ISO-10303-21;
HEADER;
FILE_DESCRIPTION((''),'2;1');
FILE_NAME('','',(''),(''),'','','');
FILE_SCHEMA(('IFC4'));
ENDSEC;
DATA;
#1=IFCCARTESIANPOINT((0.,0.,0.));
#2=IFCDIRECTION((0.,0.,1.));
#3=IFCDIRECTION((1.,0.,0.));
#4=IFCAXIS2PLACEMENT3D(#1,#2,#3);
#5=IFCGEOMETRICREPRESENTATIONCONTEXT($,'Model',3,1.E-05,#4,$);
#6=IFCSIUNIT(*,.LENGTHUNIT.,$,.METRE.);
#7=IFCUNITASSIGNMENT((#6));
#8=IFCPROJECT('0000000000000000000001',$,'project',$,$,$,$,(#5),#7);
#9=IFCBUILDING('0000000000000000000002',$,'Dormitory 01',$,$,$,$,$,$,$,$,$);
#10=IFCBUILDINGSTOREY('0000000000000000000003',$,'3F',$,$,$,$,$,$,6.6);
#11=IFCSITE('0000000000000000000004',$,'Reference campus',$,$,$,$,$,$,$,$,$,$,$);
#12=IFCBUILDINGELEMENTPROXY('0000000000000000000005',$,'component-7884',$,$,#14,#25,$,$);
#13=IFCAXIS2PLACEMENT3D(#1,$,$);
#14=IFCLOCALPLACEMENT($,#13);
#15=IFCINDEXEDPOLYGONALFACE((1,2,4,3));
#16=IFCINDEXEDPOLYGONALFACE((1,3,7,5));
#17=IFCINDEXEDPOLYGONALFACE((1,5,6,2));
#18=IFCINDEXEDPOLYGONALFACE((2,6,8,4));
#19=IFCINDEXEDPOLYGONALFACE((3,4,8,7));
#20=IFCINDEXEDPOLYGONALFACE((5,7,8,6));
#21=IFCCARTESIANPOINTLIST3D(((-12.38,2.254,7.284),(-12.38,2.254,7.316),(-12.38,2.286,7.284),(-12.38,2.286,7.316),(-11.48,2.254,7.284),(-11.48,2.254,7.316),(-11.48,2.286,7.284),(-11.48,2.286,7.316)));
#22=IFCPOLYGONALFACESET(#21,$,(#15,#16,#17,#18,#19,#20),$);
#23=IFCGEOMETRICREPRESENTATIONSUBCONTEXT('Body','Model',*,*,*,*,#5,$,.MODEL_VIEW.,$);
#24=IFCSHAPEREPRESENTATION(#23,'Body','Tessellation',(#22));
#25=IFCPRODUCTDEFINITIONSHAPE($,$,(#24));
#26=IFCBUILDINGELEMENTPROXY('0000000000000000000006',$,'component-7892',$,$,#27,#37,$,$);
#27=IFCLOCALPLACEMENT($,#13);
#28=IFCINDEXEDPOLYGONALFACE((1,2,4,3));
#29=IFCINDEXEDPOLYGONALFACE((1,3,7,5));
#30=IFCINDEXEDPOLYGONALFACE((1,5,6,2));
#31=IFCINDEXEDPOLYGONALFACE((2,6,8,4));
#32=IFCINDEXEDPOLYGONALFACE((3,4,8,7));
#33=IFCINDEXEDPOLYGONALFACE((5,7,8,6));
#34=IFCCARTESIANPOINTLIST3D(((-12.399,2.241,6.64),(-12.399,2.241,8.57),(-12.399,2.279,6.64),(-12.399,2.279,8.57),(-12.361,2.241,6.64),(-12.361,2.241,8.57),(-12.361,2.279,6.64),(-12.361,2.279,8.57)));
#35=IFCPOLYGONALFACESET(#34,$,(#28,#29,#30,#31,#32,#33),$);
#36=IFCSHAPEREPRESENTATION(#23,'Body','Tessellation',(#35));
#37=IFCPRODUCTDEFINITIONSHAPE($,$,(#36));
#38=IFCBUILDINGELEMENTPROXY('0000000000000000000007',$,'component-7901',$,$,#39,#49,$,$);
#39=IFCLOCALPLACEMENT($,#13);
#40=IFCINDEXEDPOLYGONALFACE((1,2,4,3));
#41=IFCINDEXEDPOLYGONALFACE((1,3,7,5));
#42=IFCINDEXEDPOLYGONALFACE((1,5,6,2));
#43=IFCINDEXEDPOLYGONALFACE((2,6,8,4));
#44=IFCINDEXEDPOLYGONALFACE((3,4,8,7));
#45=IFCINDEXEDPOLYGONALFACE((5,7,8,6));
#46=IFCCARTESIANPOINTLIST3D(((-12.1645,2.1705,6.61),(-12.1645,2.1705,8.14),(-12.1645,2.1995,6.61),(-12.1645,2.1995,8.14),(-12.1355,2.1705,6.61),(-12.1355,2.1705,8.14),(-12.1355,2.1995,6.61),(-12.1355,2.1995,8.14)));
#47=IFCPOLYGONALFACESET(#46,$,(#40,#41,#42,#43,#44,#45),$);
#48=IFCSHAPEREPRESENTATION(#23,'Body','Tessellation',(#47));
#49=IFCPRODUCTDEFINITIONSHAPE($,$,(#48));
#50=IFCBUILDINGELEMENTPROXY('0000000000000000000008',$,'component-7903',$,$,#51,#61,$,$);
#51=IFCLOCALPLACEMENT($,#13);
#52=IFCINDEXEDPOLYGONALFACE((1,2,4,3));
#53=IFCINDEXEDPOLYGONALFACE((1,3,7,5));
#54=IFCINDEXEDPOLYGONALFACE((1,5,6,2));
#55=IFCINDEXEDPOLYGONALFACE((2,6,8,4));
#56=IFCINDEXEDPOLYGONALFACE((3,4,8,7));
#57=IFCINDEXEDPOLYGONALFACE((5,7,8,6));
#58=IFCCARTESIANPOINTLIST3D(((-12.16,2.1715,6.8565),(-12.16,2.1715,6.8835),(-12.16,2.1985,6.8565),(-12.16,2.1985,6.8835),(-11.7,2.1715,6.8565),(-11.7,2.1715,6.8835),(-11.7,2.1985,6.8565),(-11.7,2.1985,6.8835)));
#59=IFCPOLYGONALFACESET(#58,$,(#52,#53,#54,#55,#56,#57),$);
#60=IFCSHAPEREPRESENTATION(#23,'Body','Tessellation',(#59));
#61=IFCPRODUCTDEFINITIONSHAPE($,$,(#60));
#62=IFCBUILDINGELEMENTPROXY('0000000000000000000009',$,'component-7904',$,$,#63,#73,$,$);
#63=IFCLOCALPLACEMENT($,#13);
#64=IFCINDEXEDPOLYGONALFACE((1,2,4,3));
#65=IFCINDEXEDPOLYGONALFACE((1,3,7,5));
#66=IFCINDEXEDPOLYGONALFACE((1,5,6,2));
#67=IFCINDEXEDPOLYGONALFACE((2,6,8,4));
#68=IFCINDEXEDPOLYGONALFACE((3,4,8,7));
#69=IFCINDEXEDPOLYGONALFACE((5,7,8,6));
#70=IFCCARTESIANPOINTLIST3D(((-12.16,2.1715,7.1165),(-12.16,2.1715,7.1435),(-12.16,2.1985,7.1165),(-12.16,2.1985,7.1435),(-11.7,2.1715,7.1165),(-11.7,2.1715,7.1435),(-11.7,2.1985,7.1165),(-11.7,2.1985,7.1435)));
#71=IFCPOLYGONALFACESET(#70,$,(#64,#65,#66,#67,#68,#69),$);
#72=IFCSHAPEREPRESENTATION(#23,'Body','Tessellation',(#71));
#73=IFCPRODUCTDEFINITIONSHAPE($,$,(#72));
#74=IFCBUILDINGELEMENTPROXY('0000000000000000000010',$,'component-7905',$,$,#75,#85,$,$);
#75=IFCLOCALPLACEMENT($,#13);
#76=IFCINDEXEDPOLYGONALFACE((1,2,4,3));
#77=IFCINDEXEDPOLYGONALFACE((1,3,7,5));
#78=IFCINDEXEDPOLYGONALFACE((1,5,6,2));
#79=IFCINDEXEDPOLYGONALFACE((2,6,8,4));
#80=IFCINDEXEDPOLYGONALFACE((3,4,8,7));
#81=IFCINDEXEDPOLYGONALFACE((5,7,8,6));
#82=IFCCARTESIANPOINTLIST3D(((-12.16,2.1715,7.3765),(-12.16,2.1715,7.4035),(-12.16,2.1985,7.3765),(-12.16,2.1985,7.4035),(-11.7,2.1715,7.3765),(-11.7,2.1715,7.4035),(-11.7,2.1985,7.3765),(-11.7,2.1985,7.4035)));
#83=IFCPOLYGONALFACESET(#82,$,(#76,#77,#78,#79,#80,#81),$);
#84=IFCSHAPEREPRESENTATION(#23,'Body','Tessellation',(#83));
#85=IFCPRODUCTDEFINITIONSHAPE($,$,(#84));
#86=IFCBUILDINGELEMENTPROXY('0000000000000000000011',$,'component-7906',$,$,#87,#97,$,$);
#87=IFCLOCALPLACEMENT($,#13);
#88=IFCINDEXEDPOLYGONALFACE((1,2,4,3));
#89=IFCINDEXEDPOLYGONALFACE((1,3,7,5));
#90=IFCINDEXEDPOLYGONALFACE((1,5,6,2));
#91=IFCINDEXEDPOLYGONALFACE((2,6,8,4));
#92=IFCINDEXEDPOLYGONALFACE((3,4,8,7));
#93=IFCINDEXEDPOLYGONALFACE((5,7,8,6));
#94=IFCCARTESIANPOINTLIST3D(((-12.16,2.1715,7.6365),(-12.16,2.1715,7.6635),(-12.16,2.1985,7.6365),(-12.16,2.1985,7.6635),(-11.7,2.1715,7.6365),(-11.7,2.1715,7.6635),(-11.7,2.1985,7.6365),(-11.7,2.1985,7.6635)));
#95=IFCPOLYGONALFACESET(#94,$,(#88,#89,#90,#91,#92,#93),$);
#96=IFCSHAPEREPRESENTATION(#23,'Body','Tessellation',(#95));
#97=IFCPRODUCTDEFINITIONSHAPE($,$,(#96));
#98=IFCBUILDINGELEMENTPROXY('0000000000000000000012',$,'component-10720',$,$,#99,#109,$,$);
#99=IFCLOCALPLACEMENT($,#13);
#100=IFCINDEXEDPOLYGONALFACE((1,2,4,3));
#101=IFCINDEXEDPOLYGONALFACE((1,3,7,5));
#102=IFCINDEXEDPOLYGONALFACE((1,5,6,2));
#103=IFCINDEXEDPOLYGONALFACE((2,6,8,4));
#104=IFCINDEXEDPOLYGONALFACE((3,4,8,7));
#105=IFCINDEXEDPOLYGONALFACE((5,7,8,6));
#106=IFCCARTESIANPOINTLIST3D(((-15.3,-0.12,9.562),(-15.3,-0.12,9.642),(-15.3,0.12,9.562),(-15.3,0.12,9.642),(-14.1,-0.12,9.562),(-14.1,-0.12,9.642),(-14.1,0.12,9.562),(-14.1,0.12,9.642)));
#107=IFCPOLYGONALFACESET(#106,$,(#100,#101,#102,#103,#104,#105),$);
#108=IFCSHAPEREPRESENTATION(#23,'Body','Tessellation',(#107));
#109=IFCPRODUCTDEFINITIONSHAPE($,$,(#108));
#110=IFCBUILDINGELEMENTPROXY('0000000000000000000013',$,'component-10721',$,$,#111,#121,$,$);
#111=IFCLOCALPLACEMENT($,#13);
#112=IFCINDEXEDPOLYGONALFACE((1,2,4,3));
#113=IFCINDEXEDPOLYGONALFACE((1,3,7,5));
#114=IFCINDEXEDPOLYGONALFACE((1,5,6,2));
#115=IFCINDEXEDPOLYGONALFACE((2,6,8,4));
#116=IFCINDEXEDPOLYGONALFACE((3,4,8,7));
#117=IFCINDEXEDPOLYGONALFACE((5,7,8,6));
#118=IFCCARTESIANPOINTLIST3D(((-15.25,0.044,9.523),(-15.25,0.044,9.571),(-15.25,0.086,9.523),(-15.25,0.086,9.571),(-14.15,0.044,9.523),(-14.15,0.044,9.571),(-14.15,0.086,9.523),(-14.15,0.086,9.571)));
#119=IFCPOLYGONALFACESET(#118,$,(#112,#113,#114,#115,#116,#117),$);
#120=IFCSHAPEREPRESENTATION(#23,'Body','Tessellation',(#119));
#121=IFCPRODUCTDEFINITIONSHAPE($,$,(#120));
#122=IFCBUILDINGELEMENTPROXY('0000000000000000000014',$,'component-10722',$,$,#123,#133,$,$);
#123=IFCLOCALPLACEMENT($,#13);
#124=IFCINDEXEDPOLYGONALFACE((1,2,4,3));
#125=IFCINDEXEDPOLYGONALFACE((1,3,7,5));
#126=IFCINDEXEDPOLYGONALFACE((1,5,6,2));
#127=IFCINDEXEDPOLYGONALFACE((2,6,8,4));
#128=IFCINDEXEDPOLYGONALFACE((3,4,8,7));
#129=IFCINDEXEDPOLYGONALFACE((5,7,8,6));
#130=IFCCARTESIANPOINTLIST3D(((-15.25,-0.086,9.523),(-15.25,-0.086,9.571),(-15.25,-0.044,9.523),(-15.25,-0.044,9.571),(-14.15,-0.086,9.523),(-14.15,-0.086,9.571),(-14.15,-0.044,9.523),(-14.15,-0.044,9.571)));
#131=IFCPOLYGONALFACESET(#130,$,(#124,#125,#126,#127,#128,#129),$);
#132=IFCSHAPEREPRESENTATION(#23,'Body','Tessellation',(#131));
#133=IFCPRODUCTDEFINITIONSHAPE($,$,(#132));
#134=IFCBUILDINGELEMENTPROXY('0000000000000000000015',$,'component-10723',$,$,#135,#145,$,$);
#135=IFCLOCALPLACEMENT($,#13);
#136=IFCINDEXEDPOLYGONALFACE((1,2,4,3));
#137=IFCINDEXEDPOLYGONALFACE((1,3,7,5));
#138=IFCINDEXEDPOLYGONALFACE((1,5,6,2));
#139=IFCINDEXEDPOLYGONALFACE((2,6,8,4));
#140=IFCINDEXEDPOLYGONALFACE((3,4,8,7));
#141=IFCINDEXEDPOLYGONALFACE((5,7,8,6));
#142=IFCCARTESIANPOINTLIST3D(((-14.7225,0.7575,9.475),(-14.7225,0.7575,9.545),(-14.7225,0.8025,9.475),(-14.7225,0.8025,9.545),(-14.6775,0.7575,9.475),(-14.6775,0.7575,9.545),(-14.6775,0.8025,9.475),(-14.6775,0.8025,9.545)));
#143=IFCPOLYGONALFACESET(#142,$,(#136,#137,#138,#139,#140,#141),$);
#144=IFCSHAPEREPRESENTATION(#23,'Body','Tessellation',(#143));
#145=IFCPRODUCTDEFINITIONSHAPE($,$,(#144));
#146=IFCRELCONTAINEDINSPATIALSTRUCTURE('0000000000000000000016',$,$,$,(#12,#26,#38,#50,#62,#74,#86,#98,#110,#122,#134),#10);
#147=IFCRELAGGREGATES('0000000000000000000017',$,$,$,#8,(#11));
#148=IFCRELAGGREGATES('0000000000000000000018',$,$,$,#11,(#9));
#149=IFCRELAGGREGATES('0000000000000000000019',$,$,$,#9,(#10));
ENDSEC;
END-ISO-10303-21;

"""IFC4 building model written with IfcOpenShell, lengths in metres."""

from ifc_helpers import new_model, si_unit, frame, origin, origin_with_axes, origin_2d, place, context, subcontext, project, spatial, rectangle, extrude, element, save


model = new_model("IFC4")

# Units and contexts
model_context = context("Model", 3, precision=1e-05, world=origin_with_axes())
body_context = subcontext(model_context, "Body", "Model", "MODEL_VIEW")
ifc_project = project(units=[si_unit("LENGTHUNIT", "METRE")], contexts=[model_context])

# Site, building, storey
site = spatial("IfcSite", under=ifc_project, Name="Reference campus")
building = spatial("IfcBuilding", under=site, Name="Dormitory 01")
storey = spatial("IfcBuildingStorey", under=building, Name="3F", Elevation=6.6)

# Building element proxies
proxy_1_placement = place(None, frame((-11.93, 2.27, 7.284), z_axis=(0.0, 0.0, 1.0), x_axis=(1.0, 0.0, 0.0)))
element("IfcBuildingElementProxy", 1, at=proxy_1_placement, inside=storey, Name="component-7884", context=body_context, shape_type="SweptSolid", body=[
    extrude(rectangle(XDim=0.9, YDim=0.032, at=origin_2d()), origin(), (0.0, 0.0, 1.0), 0.032),
])
proxy_2_placement = place(None, frame((-12.38, 2.26, 6.64), z_axis=(0.0, 0.0, 1.0), x_axis=(1.0, 0.0, 0.0)))
element("IfcBuildingElementProxy", 2, at=proxy_2_placement, inside=storey, Name="component-7892", context=body_context, shape_type="SweptSolid", body=[
    extrude(rectangle(XDim=0.038, YDim=0.038, at=origin_2d()), origin(), (0.0, 0.0, 1.0), 1.93),
])
proxy_3_placement = place(None, frame((-12.15, 2.185, 6.61), z_axis=(0.0, 0.0, 1.0), x_axis=(1.0, 0.0, 0.0)))
element("IfcBuildingElementProxy", 3, at=proxy_3_placement, inside=storey, Name="component-7901", context=body_context, shape_type="SweptSolid", body=[
    extrude(rectangle(XDim=0.029, YDim=0.029, at=origin_2d()), origin(), (0.0, 0.0, 1.0), 1.53),
])
for number, where, z_axis, x_axis, name in (
    (4, (-11.93, 2.185, 6.8565), (0.0, 0.0, 1.0), (1.0, 0.0, 0.0), "component-7903"),
    (5, (-11.93, 2.185, 7.1165), (0.0, 0.0, 1.0), (1.0, 0.0, 0.0), "component-7904"),
    (6, (-11.93, 2.185, 7.3765), (0.0, 0.0, 1.0), (1.0, 0.0, 0.0), "component-7905"),
    (7, (-11.93, 2.185, 7.6365), (0.0, 0.0, 1.0), (1.0, 0.0, 0.0), "component-7906"),
):
    element("IfcBuildingElementProxy", number, at=place(None, frame(where, z_axis=z_axis, x_axis=x_axis)), inside=storey, Name=name, context=body_context, shape_type="SweptSolid", body=[
        extrude(rectangle(XDim=0.46, YDim=0.027, at=origin_2d()), origin(), (0.0, 0.0, 1.0), 0.027),
    ])
proxy_4_placement = place(None, frame((-14.7, 0.0, 9.562), z_axis=(0.0, 0.0, 1.0), x_axis=(1.0, 0.0, 0.0)))
element("IfcBuildingElementProxy", 8, at=proxy_4_placement, inside=storey, Name="component-10720", context=body_context, shape_type="SweptSolid", body=[
    extrude(rectangle(XDim=1.2, YDim=0.24, at=origin_2d()), origin(), (0.0, 0.0, 1.0), 0.08),
])
for number, where, z_axis, x_axis, name in (
    (9, (-14.7, 0.065, 9.523), (0.0, 0.0, 1.0), (1.0, 0.0, 0.0), "component-10721"),
    (10, (-14.7, -0.065, 9.523), (0.0, 0.0, 1.0), (1.0, 0.0, 0.0), "component-10722"),
):
    element("IfcBuildingElementProxy", number, at=place(None, frame(where, z_axis=z_axis, x_axis=x_axis)), inside=storey, Name=name, context=body_context, shape_type="SweptSolid", body=[
        extrude(rectangle(XDim=1.1, YDim=0.042, at=origin_2d()), origin(), (0.0, 0.0, 1.0), 0.048),
    ])
proxy_5_placement = place(None, frame((-14.7, 0.78, 9.475), z_axis=(0.0, 0.0, 1.0), x_axis=(1.0, 0.0, 0.0)))
element("IfcBuildingElementProxy", 11, at=proxy_5_placement, inside=storey, Name="component-10723", context=body_context, shape_type="SweptSolid", body=[
    extrude(rectangle(XDim=0.045, YDim=0.045, at=origin_2d()), origin(), (0.0, 0.0, 1.0), 0.07),
])

save(model, "model.ifc")
